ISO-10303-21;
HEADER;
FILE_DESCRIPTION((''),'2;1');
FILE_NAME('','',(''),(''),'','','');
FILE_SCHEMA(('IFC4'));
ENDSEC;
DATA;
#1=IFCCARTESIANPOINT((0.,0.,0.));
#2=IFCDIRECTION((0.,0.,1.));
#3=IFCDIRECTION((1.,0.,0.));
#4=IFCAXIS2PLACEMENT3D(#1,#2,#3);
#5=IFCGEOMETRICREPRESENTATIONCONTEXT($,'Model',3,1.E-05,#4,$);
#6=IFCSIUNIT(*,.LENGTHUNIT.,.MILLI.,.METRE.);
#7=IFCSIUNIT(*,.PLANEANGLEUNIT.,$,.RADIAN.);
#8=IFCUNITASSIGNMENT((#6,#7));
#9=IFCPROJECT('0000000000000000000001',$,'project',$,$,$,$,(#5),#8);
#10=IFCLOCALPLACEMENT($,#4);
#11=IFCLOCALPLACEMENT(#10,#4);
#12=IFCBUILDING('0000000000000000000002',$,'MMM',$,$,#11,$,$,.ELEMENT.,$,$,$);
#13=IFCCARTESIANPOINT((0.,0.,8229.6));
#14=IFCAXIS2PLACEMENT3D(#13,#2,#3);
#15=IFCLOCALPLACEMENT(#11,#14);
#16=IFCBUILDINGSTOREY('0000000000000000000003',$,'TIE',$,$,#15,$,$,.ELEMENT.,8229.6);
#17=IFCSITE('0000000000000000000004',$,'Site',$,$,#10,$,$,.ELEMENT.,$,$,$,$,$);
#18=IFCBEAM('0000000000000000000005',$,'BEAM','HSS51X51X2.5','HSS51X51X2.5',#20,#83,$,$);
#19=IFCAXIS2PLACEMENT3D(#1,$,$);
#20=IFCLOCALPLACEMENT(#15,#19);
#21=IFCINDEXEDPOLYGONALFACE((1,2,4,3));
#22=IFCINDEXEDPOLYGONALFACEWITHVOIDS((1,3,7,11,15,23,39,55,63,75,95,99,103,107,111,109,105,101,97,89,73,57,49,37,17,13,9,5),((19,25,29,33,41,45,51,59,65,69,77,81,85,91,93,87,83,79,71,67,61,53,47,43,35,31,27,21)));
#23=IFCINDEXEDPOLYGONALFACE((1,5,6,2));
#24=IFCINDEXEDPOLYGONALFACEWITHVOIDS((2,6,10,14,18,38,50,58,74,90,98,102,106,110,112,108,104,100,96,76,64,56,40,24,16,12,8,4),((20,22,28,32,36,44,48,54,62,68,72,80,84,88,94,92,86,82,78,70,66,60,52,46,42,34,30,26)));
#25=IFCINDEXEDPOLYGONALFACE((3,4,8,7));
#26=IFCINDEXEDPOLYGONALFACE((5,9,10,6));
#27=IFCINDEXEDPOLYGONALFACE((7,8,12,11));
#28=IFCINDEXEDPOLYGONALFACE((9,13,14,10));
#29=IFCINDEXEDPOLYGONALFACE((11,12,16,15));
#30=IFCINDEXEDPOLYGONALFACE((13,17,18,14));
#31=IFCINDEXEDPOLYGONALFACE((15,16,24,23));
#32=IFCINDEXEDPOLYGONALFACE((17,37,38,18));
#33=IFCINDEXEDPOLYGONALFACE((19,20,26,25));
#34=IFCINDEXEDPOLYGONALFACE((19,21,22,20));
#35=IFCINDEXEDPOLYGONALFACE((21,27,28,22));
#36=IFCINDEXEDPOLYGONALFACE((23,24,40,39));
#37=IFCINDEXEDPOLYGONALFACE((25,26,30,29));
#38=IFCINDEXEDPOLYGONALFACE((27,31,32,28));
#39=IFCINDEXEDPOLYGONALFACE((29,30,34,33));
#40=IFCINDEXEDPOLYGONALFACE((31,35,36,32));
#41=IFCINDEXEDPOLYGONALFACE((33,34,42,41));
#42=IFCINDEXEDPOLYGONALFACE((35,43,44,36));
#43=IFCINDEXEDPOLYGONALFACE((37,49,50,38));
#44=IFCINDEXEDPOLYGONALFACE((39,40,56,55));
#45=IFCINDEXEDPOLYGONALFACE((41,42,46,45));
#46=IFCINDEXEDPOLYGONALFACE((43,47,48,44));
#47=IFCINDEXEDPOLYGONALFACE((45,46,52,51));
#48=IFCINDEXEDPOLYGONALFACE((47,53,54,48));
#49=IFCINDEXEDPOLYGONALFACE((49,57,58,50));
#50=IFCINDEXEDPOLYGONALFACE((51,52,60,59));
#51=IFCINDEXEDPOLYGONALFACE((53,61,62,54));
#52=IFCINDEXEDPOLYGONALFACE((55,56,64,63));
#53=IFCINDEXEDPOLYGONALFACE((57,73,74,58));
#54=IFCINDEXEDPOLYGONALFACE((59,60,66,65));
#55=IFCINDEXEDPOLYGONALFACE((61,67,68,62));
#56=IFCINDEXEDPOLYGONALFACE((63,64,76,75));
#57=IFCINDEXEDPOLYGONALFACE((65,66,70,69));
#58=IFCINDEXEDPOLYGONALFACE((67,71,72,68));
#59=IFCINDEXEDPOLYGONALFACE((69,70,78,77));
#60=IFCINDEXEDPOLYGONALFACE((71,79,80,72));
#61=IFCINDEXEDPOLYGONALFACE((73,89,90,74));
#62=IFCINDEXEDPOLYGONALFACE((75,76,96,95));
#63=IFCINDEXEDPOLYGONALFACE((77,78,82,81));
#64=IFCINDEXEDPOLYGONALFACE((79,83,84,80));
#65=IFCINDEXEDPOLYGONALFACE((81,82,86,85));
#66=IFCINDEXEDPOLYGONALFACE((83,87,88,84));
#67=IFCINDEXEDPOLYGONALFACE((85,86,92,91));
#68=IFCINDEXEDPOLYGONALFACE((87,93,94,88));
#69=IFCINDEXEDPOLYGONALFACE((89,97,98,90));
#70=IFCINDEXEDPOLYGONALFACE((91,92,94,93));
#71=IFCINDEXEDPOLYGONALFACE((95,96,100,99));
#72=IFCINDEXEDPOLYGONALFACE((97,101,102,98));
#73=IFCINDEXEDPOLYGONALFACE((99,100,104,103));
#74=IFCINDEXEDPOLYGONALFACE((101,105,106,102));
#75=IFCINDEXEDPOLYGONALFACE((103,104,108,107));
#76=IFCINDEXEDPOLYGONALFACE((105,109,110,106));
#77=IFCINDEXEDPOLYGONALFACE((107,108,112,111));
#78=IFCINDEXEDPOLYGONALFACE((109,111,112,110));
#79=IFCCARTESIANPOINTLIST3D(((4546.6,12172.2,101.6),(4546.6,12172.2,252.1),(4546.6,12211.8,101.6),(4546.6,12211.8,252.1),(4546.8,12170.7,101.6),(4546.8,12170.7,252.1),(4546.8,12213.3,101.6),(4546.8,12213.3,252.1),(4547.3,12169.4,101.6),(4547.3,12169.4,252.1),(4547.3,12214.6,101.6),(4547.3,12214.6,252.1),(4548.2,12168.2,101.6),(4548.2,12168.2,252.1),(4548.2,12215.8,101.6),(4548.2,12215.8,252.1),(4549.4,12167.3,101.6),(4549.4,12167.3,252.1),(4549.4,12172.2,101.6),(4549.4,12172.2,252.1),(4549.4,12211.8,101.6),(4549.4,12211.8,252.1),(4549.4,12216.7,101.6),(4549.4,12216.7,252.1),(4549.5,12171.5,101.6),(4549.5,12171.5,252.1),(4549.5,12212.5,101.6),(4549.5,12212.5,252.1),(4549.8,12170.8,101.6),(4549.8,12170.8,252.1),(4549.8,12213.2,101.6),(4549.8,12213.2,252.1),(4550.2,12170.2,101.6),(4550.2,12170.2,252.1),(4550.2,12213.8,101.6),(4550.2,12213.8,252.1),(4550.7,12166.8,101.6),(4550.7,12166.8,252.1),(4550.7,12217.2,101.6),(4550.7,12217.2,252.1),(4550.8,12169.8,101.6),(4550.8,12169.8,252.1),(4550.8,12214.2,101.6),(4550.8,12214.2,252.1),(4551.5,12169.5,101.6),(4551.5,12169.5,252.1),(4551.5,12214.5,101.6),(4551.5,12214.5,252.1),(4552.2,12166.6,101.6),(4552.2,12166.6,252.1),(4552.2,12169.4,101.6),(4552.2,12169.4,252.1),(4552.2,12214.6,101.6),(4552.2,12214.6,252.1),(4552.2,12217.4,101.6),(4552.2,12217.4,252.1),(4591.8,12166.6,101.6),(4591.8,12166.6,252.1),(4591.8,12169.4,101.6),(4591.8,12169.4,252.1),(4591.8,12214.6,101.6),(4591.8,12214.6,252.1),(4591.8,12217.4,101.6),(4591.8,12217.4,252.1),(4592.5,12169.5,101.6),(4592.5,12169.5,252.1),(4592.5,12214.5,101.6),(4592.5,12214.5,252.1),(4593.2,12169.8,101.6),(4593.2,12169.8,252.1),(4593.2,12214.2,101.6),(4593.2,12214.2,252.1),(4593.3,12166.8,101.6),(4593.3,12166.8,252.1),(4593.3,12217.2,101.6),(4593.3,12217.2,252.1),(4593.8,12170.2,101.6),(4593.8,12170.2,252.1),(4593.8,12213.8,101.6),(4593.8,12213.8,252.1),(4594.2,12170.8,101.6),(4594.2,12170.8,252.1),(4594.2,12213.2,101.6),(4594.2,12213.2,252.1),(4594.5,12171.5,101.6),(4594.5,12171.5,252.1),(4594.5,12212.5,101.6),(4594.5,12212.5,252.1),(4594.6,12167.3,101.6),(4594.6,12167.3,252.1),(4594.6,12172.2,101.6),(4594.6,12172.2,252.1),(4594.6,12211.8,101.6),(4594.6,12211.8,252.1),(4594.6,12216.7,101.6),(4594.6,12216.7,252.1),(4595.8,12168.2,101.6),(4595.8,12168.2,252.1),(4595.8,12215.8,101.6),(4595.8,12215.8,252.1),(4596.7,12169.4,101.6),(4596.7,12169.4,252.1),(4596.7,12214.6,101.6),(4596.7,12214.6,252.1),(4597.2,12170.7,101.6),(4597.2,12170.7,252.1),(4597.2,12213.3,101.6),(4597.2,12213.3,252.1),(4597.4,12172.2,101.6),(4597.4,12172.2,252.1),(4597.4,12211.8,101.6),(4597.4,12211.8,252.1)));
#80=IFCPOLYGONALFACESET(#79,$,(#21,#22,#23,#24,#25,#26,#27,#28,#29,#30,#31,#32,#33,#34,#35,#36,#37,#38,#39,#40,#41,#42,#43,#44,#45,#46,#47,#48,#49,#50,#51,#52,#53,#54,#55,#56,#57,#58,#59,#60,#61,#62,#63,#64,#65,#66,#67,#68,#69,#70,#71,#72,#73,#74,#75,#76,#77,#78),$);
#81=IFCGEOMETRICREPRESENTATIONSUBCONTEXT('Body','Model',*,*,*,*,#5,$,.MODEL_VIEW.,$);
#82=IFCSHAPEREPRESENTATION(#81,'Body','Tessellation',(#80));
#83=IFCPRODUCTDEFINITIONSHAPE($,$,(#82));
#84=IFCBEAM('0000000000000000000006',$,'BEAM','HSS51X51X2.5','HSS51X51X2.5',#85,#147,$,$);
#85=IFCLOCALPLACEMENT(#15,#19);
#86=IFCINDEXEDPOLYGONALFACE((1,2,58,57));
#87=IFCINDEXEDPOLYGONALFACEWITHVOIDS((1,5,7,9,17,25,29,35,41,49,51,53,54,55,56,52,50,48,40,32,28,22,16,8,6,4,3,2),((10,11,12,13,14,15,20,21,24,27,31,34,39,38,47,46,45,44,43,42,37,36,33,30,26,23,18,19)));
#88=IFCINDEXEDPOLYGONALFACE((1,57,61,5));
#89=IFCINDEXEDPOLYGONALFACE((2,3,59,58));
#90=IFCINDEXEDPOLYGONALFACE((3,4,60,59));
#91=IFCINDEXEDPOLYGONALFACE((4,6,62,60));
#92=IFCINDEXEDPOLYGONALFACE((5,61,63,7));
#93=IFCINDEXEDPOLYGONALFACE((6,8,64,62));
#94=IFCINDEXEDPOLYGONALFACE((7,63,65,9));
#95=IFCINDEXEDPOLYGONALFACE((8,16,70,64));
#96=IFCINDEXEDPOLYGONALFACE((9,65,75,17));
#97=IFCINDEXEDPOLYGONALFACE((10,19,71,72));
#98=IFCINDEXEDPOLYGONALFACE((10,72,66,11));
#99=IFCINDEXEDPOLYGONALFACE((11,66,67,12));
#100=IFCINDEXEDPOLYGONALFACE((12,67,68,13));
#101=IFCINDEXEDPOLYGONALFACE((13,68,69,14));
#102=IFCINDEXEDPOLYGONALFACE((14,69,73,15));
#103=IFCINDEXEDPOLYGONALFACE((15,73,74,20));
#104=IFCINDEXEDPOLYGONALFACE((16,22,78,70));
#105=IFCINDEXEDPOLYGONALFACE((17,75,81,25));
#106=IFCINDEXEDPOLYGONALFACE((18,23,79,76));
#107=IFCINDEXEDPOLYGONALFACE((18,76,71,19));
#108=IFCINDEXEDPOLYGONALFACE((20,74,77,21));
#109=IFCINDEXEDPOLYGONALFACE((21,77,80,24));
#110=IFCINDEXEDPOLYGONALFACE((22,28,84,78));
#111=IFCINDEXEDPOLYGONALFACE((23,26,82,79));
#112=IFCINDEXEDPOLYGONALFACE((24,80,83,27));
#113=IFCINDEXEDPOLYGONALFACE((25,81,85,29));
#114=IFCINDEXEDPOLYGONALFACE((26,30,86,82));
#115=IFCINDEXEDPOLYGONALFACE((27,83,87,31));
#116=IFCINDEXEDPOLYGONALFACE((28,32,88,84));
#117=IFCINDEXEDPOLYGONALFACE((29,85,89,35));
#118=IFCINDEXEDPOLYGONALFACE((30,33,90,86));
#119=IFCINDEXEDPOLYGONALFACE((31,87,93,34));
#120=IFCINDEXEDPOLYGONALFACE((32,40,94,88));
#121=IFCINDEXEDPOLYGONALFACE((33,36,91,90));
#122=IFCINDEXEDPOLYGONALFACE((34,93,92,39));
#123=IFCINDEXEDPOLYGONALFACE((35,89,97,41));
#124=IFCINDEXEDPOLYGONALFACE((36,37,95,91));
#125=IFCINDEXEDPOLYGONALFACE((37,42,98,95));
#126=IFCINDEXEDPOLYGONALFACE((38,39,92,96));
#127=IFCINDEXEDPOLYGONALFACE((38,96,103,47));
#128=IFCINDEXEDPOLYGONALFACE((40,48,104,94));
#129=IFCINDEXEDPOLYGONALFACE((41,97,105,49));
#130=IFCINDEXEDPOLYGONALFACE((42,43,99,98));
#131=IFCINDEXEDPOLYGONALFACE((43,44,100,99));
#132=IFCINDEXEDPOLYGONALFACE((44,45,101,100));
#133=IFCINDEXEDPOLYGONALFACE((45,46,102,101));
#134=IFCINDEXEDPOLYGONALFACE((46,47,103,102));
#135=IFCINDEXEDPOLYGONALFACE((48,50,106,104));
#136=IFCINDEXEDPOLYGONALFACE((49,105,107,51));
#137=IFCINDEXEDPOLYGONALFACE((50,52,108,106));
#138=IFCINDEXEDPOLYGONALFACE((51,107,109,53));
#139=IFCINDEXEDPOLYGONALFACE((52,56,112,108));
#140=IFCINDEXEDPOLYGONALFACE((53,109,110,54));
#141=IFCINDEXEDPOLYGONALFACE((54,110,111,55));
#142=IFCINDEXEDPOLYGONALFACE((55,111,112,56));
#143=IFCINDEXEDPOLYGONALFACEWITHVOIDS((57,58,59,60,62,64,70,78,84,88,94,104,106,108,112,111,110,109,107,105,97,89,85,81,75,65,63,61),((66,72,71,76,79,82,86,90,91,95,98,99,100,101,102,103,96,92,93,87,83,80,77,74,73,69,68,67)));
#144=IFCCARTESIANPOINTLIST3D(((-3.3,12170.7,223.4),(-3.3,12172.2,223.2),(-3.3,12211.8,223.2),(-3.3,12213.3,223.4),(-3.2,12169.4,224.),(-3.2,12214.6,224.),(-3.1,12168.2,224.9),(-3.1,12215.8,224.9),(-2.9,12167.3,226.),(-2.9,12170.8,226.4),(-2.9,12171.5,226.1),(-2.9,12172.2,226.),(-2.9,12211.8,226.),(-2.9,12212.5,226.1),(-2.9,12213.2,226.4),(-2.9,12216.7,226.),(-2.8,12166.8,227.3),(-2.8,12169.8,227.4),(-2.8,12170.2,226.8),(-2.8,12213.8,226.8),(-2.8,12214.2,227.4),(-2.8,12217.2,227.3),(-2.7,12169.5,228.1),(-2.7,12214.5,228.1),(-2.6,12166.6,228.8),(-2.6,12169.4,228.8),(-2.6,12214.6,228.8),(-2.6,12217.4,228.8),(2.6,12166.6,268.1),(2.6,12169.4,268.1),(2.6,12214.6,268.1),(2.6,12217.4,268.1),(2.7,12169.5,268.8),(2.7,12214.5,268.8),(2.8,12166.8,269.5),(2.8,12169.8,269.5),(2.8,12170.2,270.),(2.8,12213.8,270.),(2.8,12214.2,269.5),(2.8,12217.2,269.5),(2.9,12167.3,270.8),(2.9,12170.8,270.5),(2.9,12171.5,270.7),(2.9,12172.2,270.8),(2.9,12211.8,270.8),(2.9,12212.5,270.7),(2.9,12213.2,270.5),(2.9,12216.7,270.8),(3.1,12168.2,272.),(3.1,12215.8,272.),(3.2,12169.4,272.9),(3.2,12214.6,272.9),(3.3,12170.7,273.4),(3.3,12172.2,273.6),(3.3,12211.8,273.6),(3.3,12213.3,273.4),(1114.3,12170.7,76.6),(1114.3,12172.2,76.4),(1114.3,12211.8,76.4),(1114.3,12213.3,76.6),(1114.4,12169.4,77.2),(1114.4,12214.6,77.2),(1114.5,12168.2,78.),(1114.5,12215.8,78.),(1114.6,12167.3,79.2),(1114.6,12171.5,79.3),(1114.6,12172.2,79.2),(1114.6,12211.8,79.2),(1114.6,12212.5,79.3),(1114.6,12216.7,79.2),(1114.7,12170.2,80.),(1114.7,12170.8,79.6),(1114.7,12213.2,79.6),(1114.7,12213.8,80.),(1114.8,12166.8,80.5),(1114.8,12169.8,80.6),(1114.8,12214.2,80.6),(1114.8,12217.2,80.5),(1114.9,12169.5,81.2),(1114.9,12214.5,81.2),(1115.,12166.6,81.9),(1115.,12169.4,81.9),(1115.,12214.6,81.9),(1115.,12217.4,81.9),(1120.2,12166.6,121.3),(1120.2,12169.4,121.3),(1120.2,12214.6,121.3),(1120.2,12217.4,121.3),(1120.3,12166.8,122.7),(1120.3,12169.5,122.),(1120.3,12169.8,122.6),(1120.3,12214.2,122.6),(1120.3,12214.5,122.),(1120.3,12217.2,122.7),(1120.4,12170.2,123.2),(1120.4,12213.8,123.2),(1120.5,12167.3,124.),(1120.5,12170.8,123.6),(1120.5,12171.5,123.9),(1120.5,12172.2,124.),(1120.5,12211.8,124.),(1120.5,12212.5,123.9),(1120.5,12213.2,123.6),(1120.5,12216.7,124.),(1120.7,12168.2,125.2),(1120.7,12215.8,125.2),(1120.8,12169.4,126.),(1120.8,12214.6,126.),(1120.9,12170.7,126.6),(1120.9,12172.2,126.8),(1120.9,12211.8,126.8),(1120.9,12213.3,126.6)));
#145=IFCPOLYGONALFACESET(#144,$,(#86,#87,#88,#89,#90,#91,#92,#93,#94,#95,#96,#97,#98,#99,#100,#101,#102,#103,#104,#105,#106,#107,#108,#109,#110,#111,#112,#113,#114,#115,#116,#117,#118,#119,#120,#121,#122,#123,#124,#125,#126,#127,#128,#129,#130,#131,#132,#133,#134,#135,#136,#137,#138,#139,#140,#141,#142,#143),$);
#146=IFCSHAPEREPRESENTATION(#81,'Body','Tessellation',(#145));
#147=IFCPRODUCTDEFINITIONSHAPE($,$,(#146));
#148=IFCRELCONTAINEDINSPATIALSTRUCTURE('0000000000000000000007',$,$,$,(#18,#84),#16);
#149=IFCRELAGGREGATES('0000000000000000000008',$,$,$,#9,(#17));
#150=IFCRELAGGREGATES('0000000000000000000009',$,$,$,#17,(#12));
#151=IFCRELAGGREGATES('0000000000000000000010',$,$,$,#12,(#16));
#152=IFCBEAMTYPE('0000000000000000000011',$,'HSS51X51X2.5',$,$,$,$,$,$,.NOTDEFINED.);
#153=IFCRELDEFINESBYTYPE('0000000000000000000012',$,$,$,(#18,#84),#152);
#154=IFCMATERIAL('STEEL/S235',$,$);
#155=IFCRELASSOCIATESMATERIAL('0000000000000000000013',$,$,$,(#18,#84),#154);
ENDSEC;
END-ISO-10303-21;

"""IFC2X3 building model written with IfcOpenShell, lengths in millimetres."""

from ifc_helpers import new_model, si_unit, frame, origin_with_axes, origin_2d_with_axis, place, context, subcontext, project, spatial, hollow_rectangle, extrude, material, type_object, element, save


model = new_model("IFC2X3")

# Units and contexts
model_context = context("Model", 3, precision=1e-05, world=origin_with_axes())
body_context = subcontext(model_context, "Body", "Model", "MODEL_VIEW")
ifc_project = project(units=[si_unit("LENGTHUNIT", "METRE", prefix="MILLI"), si_unit("PLANEANGLEUNIT", "RADIAN")], contexts=[model_context])

# Site, building, storey
site_placement = place(None, origin_with_axes())
site = spatial("IfcSite", under=ifc_project, at=site_placement, Name="Site", CompositionType="ELEMENT")
building_placement = place(site_placement, origin_with_axes())
building = spatial("IfcBuilding", under=site, at=building_placement, Name="MMM", CompositionType="ELEMENT")
storey_placement = place(building_placement, frame((0.0, 0.0, 8229.6), z_axis=(0.0, 0.0, 1.0), x_axis=(1.0, 0.0, 0.0)))
storey = spatial("IfcBuildingStorey", under=building, at=storey_placement, Name="TIE", CompositionType="ELEMENT", Elevation=8229.6)

# Beams
ifc_material = material(Name="STEEL/S235")
beam_type_1 = type_object("IfcBeamType", Name="HSS51X51X2.5", PredefinedType="NOTDEFINED")
beam_1_placement = place(storey_placement, frame((4572.0, 12192.0, 252.1), z_axis=(-1.0, 0.0, 0.0), x_axis=(0.0, 0.0, -1.0)))
element("IfcBeam", 1, at=beam_1_placement, inside=storey, type_object=beam_type_1, material=ifc_material, Name="BEAM", Description="HSS51X51X2.5", ObjectType="HSS51X51X2.5", context=body_context, shape_type="SweptSolid", body=[
    extrude(hollow_rectangle(XDim=50.8, YDim=50.8, WallThickness=2.8, InnerFilletRadius=2.8, OuterFilletRadius=5.6, at=origin_2d_with_axis()), frame((150.5, 0.0, 0.0), z_axis=(-1.0, 0.0, 0.0), x_axis=(0.0, -1.0, 0.0)), (0.0, 0.0, 1.0), 150.5),
])
beam_2_placement = place(storey_placement, frame((1117.6, 12192.0, 101.6), z_axis=(0.130258, 0.0, 0.99148), x_axis=(-0.99148, 0.0, 0.130258)))
element("IfcBeam", 2, at=beam_2_placement, inside=storey, type_object=beam_type_1, material=ifc_material, Name="BEAM", Description="HSS51X51X2.5", ObjectType="HSS51X51X2.5", context=body_context, shape_type="SweptSolid", body=[
    extrude(hollow_rectangle(XDim=50.8, YDim=50.8, WallThickness=2.8, InnerFilletRadius=2.8, OuterFilletRadius=5.6, at=origin_2d_with_axis()), frame((1127.2, 0.0, 0.0), z_axis=(-1.0, 0.0, 0.0), x_axis=(0.0, -1.0, 0.0)), (0.0, 0.0, 1.0), 1127.2),
])

save(model, "model.ifc")
